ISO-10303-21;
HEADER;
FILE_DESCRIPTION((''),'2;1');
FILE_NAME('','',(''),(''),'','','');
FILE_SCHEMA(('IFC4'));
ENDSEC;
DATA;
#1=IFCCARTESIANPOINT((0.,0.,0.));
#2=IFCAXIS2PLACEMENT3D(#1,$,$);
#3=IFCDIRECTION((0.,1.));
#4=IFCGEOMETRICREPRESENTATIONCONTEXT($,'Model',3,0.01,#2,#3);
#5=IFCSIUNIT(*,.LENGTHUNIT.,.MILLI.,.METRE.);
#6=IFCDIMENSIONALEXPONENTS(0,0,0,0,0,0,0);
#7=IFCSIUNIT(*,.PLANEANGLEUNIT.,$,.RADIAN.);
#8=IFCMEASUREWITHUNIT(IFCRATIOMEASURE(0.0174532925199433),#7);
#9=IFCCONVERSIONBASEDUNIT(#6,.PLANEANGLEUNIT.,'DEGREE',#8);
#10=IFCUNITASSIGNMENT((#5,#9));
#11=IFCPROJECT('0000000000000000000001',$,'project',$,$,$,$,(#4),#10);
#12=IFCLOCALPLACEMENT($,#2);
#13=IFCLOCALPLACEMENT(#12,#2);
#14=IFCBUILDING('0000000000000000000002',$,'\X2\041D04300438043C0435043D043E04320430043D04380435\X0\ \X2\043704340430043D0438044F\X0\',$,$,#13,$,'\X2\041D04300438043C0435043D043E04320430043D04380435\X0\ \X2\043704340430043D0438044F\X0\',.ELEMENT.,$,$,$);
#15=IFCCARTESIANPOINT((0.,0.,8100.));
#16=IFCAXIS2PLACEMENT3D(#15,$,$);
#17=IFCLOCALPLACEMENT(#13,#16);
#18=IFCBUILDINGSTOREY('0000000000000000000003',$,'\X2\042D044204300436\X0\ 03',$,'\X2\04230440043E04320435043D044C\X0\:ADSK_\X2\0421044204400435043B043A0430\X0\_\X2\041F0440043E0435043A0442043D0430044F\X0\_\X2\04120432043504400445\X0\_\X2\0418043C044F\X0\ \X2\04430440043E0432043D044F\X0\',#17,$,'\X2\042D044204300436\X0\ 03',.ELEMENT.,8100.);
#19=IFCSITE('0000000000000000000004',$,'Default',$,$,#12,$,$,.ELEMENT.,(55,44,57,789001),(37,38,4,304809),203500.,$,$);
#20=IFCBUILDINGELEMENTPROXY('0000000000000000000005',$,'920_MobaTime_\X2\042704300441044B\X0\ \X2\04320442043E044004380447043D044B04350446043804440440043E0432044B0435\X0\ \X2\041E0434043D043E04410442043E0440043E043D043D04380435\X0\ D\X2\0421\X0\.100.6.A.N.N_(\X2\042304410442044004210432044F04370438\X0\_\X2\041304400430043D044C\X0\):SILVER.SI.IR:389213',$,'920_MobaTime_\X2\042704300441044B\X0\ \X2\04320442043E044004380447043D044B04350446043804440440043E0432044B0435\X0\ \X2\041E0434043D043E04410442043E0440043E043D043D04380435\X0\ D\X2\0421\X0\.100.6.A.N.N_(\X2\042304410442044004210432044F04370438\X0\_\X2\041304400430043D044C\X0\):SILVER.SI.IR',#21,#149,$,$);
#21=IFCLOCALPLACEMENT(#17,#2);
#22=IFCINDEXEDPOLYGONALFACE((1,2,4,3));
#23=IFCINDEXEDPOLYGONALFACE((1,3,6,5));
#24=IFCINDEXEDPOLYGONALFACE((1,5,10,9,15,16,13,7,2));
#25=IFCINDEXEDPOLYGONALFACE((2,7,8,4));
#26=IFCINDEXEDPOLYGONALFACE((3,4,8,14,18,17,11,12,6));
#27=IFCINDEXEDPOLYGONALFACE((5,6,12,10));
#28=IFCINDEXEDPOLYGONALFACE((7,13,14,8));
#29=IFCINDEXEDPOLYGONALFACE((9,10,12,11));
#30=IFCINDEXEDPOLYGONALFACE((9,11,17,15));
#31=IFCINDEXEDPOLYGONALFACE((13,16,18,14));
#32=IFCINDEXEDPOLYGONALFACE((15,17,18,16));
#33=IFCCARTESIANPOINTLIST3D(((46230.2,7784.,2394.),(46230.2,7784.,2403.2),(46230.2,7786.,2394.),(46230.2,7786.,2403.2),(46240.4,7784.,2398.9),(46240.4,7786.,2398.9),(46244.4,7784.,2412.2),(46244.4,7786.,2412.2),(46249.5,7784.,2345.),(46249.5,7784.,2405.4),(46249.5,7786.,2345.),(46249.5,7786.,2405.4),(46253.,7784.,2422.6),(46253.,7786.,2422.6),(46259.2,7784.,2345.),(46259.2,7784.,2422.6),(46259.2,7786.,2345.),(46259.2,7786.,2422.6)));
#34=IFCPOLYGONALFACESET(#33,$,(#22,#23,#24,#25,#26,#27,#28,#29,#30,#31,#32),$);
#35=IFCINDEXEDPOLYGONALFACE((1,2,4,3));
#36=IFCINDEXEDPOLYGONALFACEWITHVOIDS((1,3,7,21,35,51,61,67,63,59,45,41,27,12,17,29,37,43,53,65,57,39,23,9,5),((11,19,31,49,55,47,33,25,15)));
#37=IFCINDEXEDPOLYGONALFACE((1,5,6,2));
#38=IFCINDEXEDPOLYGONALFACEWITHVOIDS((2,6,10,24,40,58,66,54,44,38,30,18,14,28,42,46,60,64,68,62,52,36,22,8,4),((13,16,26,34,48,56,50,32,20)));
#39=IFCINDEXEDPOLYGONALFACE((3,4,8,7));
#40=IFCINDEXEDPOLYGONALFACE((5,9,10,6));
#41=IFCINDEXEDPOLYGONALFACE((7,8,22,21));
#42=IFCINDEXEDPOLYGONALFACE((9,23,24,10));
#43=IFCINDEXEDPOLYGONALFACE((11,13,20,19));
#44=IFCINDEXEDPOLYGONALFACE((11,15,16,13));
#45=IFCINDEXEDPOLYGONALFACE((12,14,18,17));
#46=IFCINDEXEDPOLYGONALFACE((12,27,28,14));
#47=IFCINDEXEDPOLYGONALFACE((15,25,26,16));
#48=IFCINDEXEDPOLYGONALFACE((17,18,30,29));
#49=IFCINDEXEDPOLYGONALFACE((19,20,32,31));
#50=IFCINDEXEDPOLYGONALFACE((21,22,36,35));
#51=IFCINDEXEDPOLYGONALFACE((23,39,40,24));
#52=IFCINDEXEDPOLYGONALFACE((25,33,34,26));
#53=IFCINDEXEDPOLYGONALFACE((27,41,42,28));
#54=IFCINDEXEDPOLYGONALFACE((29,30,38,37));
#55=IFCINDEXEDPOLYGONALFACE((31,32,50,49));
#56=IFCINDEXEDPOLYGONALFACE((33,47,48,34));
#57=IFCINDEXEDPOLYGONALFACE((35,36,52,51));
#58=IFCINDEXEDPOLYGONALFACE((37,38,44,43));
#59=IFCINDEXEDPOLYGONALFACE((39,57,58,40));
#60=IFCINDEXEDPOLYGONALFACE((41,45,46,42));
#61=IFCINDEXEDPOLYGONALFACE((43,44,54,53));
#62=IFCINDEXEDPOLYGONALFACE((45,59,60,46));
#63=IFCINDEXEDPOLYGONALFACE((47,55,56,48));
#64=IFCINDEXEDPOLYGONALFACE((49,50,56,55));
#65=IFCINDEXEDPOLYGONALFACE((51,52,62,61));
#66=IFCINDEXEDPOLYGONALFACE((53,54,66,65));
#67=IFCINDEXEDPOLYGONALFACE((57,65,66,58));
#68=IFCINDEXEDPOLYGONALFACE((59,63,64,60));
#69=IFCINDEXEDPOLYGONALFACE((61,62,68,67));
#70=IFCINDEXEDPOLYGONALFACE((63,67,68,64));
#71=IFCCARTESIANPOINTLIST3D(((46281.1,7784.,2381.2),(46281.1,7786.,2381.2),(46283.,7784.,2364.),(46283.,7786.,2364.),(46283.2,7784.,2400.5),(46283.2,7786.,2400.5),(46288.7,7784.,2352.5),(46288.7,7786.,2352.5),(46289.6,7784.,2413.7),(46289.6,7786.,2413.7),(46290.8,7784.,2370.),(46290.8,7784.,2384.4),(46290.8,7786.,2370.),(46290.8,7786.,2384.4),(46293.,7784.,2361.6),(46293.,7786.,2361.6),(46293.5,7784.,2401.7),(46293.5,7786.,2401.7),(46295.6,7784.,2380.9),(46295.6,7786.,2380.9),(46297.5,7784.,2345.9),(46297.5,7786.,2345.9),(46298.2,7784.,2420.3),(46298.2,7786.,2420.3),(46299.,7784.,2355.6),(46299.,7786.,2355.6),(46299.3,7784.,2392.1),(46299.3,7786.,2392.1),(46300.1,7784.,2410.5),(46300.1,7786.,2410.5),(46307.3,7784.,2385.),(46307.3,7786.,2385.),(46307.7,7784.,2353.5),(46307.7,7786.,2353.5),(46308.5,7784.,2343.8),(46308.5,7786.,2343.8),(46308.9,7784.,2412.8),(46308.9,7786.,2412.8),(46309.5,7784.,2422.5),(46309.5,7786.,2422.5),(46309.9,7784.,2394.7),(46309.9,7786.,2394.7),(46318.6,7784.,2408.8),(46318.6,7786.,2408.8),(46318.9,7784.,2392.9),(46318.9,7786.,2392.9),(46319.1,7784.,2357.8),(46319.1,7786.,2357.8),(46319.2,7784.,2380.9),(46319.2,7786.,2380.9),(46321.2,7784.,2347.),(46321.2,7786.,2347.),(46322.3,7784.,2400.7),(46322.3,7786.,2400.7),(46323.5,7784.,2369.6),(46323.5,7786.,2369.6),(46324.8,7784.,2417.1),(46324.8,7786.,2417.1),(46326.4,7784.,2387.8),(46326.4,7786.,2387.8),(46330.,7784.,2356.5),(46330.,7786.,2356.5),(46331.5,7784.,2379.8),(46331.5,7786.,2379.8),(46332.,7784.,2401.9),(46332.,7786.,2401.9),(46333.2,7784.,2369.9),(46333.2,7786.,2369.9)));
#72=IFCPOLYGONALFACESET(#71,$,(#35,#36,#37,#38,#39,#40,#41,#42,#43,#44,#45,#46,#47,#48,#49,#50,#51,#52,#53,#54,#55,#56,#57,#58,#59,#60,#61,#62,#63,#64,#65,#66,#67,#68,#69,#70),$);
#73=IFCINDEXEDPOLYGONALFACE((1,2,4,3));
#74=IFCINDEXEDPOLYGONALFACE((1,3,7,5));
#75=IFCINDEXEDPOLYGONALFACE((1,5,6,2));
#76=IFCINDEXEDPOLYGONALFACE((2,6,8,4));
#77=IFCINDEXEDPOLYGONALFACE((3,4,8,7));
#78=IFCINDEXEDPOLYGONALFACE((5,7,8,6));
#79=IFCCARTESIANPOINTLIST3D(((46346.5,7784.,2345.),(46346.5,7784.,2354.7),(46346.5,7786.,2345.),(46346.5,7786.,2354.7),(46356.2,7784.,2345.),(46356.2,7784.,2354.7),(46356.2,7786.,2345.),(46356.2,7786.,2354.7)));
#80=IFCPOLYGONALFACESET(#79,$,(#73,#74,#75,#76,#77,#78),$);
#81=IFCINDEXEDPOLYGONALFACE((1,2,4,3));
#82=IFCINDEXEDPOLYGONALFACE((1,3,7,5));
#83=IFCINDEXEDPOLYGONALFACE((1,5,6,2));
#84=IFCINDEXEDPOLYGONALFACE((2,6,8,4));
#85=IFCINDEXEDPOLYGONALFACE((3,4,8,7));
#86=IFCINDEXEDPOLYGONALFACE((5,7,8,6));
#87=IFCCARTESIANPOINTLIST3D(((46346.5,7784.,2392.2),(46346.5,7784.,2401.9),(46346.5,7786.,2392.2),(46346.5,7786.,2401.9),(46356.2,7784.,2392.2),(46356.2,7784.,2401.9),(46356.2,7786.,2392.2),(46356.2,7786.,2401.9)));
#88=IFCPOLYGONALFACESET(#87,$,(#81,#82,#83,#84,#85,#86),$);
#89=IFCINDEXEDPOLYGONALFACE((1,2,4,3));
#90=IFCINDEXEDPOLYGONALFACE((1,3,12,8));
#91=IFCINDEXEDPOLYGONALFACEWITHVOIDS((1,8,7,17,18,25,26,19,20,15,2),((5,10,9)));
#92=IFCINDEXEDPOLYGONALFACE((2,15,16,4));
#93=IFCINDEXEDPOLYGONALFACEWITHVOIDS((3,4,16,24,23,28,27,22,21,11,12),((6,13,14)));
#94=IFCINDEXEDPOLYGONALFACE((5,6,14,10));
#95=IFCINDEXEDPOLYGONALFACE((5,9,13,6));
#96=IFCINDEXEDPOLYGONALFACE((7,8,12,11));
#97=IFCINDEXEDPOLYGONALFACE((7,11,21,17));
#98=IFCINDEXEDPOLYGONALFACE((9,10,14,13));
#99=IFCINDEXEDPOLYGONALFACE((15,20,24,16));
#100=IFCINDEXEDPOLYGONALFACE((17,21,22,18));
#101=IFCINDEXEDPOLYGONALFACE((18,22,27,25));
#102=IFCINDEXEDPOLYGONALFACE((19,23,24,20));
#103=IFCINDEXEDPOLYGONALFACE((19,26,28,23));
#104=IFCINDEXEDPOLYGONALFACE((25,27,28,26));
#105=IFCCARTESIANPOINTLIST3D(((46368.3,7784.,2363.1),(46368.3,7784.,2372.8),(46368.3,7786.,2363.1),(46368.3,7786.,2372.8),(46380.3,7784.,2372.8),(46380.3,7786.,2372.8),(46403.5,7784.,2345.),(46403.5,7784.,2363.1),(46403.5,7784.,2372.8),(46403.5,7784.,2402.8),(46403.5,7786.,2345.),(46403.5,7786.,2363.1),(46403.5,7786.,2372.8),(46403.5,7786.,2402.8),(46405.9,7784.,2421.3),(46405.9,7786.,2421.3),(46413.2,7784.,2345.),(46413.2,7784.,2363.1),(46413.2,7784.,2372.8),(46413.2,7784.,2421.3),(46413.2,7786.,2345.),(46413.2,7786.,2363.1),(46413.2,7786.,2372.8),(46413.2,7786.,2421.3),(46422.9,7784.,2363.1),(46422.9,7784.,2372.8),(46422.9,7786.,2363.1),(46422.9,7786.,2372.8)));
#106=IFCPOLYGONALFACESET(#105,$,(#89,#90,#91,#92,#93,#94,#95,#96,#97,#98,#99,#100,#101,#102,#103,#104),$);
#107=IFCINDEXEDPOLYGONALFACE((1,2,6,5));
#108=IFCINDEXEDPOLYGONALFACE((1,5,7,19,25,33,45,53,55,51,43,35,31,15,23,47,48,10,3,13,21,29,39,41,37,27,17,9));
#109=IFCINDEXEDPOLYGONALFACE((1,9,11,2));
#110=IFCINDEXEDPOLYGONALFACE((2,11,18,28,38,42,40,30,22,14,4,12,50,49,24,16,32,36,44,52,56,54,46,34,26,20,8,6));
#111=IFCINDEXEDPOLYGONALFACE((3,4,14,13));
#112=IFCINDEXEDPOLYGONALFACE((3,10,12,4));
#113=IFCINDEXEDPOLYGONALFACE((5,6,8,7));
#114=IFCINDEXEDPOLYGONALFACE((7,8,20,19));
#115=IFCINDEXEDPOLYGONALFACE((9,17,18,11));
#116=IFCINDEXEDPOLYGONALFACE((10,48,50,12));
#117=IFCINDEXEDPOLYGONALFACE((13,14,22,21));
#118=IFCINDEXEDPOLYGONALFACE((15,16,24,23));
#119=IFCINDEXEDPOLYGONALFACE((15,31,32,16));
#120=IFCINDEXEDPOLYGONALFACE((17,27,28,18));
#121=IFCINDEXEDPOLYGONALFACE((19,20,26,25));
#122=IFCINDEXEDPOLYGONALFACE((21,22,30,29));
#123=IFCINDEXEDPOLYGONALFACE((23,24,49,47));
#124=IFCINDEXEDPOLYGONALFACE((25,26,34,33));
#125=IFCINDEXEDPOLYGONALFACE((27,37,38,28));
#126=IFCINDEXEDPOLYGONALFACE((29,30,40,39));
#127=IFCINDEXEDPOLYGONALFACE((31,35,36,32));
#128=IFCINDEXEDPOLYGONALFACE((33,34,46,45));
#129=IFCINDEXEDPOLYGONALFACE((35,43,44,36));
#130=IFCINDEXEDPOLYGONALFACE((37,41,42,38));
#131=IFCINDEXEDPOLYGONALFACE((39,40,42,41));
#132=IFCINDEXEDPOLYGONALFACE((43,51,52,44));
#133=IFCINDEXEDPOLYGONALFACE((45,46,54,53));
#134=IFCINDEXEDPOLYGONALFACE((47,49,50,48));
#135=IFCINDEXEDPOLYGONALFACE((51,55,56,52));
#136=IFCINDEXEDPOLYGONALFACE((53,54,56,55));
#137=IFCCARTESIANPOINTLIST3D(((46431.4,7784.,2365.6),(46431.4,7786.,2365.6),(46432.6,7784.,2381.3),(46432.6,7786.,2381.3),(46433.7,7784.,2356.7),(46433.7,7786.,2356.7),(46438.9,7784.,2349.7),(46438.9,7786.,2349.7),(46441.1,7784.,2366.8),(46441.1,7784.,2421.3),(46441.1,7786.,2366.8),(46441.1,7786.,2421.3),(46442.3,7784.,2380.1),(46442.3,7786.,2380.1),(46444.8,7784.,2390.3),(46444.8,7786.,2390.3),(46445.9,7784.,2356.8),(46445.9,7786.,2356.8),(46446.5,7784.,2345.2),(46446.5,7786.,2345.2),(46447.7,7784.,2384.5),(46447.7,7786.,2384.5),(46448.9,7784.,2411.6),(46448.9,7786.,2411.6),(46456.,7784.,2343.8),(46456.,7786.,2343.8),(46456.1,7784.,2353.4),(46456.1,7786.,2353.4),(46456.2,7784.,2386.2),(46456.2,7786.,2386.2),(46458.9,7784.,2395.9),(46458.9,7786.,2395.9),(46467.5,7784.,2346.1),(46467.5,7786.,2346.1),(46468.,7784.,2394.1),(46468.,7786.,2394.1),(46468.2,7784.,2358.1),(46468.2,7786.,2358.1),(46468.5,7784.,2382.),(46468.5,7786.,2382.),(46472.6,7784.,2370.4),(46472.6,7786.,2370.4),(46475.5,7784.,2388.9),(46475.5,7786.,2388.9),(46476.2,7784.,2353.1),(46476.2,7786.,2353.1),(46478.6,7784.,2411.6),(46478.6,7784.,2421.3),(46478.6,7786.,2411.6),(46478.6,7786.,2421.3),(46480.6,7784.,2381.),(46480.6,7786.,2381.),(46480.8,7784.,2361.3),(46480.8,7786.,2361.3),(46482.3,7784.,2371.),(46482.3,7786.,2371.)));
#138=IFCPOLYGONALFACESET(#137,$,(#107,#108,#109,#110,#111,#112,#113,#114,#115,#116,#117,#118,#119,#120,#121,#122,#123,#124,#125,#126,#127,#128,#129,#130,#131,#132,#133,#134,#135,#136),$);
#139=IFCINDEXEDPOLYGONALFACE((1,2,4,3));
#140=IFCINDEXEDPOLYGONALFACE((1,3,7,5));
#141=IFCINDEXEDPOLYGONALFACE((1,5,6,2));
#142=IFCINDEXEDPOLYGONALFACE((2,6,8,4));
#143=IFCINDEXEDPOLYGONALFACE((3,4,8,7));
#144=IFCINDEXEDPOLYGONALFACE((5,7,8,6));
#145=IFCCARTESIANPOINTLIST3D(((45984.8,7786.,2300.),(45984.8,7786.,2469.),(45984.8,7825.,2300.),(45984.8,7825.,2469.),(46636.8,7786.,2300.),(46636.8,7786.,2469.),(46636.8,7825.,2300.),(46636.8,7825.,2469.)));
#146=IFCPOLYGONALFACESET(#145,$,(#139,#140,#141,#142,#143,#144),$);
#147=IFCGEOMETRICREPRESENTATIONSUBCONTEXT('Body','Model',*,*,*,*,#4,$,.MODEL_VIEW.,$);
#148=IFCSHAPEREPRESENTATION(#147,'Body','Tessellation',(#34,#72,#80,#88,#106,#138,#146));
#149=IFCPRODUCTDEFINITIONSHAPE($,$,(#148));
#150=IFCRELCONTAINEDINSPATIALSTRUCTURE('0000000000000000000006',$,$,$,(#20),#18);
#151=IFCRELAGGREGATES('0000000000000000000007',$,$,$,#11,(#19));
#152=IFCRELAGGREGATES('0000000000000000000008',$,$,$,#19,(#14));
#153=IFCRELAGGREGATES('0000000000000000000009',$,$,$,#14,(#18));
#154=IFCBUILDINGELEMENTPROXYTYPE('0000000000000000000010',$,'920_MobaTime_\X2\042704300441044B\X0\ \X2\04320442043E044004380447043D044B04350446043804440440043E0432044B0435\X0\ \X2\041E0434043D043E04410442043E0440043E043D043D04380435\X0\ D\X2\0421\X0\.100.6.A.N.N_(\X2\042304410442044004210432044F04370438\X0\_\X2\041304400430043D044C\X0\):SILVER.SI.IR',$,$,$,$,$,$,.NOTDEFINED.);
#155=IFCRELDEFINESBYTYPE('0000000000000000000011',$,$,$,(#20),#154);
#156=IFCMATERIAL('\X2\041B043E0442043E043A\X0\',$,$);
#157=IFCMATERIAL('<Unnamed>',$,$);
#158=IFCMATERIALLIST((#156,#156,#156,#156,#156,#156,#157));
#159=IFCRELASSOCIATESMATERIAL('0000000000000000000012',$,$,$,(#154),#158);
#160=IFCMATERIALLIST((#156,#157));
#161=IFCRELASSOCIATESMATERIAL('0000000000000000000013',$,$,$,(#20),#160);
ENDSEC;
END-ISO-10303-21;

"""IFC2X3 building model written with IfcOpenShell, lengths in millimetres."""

from ifc_helpers import new_model, entity, si_unit, converted_unit, direction, frame, origin, origin_2d_with_axis, place, context, subcontext, project, spatial, polyline, rectangle, outline, extrude, source, transform, mapped, material, material_list, type_object, type_shapes, element, save


model = new_model("IFC2X3")

# Units and contexts
model_context = context("Model", 3, precision=0.01, world=origin(), true_north=direction((0.0, 1.0)))
body_context = subcontext(model_context, "Body", "Model", "MODEL_VIEW")
ifc_project = project(units=[si_unit("LENGTHUNIT", "METRE", prefix="MILLI"), converted_unit("PLANEANGLEUNIT", "DEGREE", entity("IfcRatioMeasure", 0.0174532925199433), si_unit("PLANEANGLEUNIT", "RADIAN"), dimensions=[0, 0, 0, 0, 0, 0, 0])], contexts=[model_context])

# Site, building, storey
site_placement = place(None, origin())
site = spatial("IfcSite", under=ifc_project, at=site_placement, Name="Default", CompositionType="ELEMENT", RefLatitude=(55, 44, 57, 789001), RefLongitude=(37, 38, 4, 304809), RefElevation=203500.0)
building_placement = place(site_placement, origin())
building = spatial("IfcBuilding", under=site, at=building_placement, Name="Наименование здания", LongName="Наименование здания", CompositionType="ELEMENT")
storey_placement = place(building_placement, frame((0.0, 0.0, 8100.0)))
storey = spatial("IfcBuildingStorey", under=building, at=storey_placement, Name="Этаж 03", ObjectType="Уровень:ADSK_Стрелка_Проектная_Вверх_Имя уровня", LongName="Этаж 03", CompositionType="ELEMENT", Elevation=8100.0)

# Building element proxy
ifc_material_1 = material(Name="Лоток")
ifc_material_2 = material(Name="<Unnamed>")
ifc_material_list_1 = material_list([ifc_material_1, ifc_material_1, ifc_material_1, ifc_material_1, ifc_material_1, ifc_material_1, ifc_material_2])
building_element_proxy_type = type_object("IfcBuildingElementProxyType", Name="920_MobaTime_Часы вторичныецифровые Односторонние DС.100.6.A.N.N_(УстрСвязи_Грань):SILVER.SI.IR", PredefinedType="NOTDEFINED", material=ifc_material_list_1)
shared_shape = source(origin(), body_context, "Body", "SweptSolid", [
    extrude(outline(polyline([(-49.3, -13.1), (28.2, -13.1), (28.2, -6.8), (17.9, 1.8), (8.8, 16.0), (-0.3, 16.0), (4.6, 5.8), (11.1, -3.4), (-49.3, -3.4), (-49.3, -13.1)])), frame((-64.6, 9.8, 39.0), z_axis=(0.0, 0.0, 1.0), x_axis=(0.0, 1.0, 0.0)), (0.0, 0.0, 1.0), 2.0),
    extrude(outline(polyline([(2.2, -27.6), (19.0, -27.6), (30.5, -16.1), (33.3, -4.9), (31.0, 5.8), (21.8, 17.2), (5.2, 27.3), (-11.1, 33.0), (-24.0, 32.7), (-33.6, 27.6), (-40.3, 18.6), (-42.8, 5.7), (-38.0, -6.3), (-27.2, -14.9), (-17.5, -17.7), (-8.2, -16.4), (-0.3, -11.9), (5.1, -4.5), (7.3, 6.2), (4.0, 17.2), (18.4, 7.3), (23.6, -2.4), (22.0, -11.4), (14.2, -18.4), (5.3, -18.3), (2.2, -27.6)]), holes=[polyline([(-9.0, 23.3), (-1.3, 14.3), (-2.5, 2.0), (-11.4, -7.0), (-23.4, -6.0), (-32.2, 2.9), (-31.2, 15.1), (-25.6, 22.1), (-17.5, 24.9), (-9.0, 23.3)])]), frame((-2.7, 3.6, 39.0), z_axis=(0.0, 0.0, 1.0), x_axis=(-0.427649, 0.903945, 0.0)), (0.0, 0.0, 1.0), 2.0),
    extrude(rectangle(XDim=9.7, YDim=9.7, at=origin_2d_with_axis()), frame((40.6, -34.7, 39.0)), (0.0, 0.0, 1.0), 2.0),
    extrude(rectangle(XDim=9.7, YDim=9.7, at=origin_2d_with_axis()), frame((40.6, 12.6, 39.0)), (0.0, 0.0, 1.0), 2.0),
    extrude(outline(polyline([(-0.9, -28.1), (8.8, -28.1), (8.8, -9.9), (18.5, -9.9), (18.5, -0.2), (8.8, -0.2), (8.8, 48.3), (1.5, 48.3), (-36.0, -0.2), (-36.0, -9.9), (-0.9, -9.9), (-0.9, -28.1)]), holes=[polyline([(-0.9, -0.2), (-24.1, -0.2), (-0.9, 29.7), (-0.9, -0.2)])]), frame((93.6, -11.4, 39.0)), (0.0, 0.0, 1.0), 2.0),
    extrude(outline(polyline([(3.3, -28.3), (12.5, -28.3), (20.5, -25.0), (26.8, -18.9), (30.7, -10.0), (31.4, 1.6), (26.9, 11.8), (20.1, 18.4), (11.1, 22.3), (1.0, 23.3), (-7.9, 20.4), (-14.9, 14.5), (-18.9, 6.2), (-17.1, -9.0), (-36.7, 0.5), (-29.1, 29.2), (-38.5, 31.7), (-48.1, -4.6), (-11.6, -23.1), (-8.0, -14.0), (-10.8, -7.6), (-10.2, 1.1), (-3.0, 11.8), (9.2, 12.8), (20.0, 5.5), (21.4, -7.5), (15.5, -16.4), (4.6, -18.6), (3.3, -28.3)])), frame((147.1, -8.5, 39.0), z_axis=(0.0, 0.0, 1.0), x_axis=(0.256974, -0.966418, 0.0)), (0.0, 0.0, 1.0), 2.0),
    extrude(rectangle(XDim=652.0, YDim=169.0, at=origin_2d_with_axis()), frame((0.0, 0.0, 0.0), z_axis=(0.0, 0.0, 1.0), x_axis=(-1.0, 0.0, 0.0)), (0.0, 0.0, 1.0), 39.0),
])
type_shapes(building_element_proxy_type, [shared_shape])
ifc_material_list_2 = material_list([ifc_material_1, ifc_material_2])
for number, where, z_axis, x_axis, name in (
    (1, (46310.8, 7825.0, 2384.5), (0.0, -1.0, 0.0), (1.0, 0.0, 0.0), "920_MobaTime_Часы вторичныецифровые Односторонние DС.100.6.A.N.N_(УстрСвязи_Грань):SILVER.SI.IR:389213"),
):
    element("IfcBuildingElementProxy", number, at=place(storey_placement, frame(where, z_axis=z_axis, x_axis=x_axis)), inside=storey, type_object=building_element_proxy_type, material=ifc_material_list_2, Name=name, ObjectType="920_MobaTime_Часы вторичныецифровые Односторонние DС.100.6.A.N.N_(УстрСвязи_Грань):SILVER.SI.IR", context=body_context, shape_type="MappedRepresentation", body=[
        mapped(shared_shape, transform((0.0, 0.0, 0.0), scale=1.0)),
    ])

save(model, "model.ifc")
